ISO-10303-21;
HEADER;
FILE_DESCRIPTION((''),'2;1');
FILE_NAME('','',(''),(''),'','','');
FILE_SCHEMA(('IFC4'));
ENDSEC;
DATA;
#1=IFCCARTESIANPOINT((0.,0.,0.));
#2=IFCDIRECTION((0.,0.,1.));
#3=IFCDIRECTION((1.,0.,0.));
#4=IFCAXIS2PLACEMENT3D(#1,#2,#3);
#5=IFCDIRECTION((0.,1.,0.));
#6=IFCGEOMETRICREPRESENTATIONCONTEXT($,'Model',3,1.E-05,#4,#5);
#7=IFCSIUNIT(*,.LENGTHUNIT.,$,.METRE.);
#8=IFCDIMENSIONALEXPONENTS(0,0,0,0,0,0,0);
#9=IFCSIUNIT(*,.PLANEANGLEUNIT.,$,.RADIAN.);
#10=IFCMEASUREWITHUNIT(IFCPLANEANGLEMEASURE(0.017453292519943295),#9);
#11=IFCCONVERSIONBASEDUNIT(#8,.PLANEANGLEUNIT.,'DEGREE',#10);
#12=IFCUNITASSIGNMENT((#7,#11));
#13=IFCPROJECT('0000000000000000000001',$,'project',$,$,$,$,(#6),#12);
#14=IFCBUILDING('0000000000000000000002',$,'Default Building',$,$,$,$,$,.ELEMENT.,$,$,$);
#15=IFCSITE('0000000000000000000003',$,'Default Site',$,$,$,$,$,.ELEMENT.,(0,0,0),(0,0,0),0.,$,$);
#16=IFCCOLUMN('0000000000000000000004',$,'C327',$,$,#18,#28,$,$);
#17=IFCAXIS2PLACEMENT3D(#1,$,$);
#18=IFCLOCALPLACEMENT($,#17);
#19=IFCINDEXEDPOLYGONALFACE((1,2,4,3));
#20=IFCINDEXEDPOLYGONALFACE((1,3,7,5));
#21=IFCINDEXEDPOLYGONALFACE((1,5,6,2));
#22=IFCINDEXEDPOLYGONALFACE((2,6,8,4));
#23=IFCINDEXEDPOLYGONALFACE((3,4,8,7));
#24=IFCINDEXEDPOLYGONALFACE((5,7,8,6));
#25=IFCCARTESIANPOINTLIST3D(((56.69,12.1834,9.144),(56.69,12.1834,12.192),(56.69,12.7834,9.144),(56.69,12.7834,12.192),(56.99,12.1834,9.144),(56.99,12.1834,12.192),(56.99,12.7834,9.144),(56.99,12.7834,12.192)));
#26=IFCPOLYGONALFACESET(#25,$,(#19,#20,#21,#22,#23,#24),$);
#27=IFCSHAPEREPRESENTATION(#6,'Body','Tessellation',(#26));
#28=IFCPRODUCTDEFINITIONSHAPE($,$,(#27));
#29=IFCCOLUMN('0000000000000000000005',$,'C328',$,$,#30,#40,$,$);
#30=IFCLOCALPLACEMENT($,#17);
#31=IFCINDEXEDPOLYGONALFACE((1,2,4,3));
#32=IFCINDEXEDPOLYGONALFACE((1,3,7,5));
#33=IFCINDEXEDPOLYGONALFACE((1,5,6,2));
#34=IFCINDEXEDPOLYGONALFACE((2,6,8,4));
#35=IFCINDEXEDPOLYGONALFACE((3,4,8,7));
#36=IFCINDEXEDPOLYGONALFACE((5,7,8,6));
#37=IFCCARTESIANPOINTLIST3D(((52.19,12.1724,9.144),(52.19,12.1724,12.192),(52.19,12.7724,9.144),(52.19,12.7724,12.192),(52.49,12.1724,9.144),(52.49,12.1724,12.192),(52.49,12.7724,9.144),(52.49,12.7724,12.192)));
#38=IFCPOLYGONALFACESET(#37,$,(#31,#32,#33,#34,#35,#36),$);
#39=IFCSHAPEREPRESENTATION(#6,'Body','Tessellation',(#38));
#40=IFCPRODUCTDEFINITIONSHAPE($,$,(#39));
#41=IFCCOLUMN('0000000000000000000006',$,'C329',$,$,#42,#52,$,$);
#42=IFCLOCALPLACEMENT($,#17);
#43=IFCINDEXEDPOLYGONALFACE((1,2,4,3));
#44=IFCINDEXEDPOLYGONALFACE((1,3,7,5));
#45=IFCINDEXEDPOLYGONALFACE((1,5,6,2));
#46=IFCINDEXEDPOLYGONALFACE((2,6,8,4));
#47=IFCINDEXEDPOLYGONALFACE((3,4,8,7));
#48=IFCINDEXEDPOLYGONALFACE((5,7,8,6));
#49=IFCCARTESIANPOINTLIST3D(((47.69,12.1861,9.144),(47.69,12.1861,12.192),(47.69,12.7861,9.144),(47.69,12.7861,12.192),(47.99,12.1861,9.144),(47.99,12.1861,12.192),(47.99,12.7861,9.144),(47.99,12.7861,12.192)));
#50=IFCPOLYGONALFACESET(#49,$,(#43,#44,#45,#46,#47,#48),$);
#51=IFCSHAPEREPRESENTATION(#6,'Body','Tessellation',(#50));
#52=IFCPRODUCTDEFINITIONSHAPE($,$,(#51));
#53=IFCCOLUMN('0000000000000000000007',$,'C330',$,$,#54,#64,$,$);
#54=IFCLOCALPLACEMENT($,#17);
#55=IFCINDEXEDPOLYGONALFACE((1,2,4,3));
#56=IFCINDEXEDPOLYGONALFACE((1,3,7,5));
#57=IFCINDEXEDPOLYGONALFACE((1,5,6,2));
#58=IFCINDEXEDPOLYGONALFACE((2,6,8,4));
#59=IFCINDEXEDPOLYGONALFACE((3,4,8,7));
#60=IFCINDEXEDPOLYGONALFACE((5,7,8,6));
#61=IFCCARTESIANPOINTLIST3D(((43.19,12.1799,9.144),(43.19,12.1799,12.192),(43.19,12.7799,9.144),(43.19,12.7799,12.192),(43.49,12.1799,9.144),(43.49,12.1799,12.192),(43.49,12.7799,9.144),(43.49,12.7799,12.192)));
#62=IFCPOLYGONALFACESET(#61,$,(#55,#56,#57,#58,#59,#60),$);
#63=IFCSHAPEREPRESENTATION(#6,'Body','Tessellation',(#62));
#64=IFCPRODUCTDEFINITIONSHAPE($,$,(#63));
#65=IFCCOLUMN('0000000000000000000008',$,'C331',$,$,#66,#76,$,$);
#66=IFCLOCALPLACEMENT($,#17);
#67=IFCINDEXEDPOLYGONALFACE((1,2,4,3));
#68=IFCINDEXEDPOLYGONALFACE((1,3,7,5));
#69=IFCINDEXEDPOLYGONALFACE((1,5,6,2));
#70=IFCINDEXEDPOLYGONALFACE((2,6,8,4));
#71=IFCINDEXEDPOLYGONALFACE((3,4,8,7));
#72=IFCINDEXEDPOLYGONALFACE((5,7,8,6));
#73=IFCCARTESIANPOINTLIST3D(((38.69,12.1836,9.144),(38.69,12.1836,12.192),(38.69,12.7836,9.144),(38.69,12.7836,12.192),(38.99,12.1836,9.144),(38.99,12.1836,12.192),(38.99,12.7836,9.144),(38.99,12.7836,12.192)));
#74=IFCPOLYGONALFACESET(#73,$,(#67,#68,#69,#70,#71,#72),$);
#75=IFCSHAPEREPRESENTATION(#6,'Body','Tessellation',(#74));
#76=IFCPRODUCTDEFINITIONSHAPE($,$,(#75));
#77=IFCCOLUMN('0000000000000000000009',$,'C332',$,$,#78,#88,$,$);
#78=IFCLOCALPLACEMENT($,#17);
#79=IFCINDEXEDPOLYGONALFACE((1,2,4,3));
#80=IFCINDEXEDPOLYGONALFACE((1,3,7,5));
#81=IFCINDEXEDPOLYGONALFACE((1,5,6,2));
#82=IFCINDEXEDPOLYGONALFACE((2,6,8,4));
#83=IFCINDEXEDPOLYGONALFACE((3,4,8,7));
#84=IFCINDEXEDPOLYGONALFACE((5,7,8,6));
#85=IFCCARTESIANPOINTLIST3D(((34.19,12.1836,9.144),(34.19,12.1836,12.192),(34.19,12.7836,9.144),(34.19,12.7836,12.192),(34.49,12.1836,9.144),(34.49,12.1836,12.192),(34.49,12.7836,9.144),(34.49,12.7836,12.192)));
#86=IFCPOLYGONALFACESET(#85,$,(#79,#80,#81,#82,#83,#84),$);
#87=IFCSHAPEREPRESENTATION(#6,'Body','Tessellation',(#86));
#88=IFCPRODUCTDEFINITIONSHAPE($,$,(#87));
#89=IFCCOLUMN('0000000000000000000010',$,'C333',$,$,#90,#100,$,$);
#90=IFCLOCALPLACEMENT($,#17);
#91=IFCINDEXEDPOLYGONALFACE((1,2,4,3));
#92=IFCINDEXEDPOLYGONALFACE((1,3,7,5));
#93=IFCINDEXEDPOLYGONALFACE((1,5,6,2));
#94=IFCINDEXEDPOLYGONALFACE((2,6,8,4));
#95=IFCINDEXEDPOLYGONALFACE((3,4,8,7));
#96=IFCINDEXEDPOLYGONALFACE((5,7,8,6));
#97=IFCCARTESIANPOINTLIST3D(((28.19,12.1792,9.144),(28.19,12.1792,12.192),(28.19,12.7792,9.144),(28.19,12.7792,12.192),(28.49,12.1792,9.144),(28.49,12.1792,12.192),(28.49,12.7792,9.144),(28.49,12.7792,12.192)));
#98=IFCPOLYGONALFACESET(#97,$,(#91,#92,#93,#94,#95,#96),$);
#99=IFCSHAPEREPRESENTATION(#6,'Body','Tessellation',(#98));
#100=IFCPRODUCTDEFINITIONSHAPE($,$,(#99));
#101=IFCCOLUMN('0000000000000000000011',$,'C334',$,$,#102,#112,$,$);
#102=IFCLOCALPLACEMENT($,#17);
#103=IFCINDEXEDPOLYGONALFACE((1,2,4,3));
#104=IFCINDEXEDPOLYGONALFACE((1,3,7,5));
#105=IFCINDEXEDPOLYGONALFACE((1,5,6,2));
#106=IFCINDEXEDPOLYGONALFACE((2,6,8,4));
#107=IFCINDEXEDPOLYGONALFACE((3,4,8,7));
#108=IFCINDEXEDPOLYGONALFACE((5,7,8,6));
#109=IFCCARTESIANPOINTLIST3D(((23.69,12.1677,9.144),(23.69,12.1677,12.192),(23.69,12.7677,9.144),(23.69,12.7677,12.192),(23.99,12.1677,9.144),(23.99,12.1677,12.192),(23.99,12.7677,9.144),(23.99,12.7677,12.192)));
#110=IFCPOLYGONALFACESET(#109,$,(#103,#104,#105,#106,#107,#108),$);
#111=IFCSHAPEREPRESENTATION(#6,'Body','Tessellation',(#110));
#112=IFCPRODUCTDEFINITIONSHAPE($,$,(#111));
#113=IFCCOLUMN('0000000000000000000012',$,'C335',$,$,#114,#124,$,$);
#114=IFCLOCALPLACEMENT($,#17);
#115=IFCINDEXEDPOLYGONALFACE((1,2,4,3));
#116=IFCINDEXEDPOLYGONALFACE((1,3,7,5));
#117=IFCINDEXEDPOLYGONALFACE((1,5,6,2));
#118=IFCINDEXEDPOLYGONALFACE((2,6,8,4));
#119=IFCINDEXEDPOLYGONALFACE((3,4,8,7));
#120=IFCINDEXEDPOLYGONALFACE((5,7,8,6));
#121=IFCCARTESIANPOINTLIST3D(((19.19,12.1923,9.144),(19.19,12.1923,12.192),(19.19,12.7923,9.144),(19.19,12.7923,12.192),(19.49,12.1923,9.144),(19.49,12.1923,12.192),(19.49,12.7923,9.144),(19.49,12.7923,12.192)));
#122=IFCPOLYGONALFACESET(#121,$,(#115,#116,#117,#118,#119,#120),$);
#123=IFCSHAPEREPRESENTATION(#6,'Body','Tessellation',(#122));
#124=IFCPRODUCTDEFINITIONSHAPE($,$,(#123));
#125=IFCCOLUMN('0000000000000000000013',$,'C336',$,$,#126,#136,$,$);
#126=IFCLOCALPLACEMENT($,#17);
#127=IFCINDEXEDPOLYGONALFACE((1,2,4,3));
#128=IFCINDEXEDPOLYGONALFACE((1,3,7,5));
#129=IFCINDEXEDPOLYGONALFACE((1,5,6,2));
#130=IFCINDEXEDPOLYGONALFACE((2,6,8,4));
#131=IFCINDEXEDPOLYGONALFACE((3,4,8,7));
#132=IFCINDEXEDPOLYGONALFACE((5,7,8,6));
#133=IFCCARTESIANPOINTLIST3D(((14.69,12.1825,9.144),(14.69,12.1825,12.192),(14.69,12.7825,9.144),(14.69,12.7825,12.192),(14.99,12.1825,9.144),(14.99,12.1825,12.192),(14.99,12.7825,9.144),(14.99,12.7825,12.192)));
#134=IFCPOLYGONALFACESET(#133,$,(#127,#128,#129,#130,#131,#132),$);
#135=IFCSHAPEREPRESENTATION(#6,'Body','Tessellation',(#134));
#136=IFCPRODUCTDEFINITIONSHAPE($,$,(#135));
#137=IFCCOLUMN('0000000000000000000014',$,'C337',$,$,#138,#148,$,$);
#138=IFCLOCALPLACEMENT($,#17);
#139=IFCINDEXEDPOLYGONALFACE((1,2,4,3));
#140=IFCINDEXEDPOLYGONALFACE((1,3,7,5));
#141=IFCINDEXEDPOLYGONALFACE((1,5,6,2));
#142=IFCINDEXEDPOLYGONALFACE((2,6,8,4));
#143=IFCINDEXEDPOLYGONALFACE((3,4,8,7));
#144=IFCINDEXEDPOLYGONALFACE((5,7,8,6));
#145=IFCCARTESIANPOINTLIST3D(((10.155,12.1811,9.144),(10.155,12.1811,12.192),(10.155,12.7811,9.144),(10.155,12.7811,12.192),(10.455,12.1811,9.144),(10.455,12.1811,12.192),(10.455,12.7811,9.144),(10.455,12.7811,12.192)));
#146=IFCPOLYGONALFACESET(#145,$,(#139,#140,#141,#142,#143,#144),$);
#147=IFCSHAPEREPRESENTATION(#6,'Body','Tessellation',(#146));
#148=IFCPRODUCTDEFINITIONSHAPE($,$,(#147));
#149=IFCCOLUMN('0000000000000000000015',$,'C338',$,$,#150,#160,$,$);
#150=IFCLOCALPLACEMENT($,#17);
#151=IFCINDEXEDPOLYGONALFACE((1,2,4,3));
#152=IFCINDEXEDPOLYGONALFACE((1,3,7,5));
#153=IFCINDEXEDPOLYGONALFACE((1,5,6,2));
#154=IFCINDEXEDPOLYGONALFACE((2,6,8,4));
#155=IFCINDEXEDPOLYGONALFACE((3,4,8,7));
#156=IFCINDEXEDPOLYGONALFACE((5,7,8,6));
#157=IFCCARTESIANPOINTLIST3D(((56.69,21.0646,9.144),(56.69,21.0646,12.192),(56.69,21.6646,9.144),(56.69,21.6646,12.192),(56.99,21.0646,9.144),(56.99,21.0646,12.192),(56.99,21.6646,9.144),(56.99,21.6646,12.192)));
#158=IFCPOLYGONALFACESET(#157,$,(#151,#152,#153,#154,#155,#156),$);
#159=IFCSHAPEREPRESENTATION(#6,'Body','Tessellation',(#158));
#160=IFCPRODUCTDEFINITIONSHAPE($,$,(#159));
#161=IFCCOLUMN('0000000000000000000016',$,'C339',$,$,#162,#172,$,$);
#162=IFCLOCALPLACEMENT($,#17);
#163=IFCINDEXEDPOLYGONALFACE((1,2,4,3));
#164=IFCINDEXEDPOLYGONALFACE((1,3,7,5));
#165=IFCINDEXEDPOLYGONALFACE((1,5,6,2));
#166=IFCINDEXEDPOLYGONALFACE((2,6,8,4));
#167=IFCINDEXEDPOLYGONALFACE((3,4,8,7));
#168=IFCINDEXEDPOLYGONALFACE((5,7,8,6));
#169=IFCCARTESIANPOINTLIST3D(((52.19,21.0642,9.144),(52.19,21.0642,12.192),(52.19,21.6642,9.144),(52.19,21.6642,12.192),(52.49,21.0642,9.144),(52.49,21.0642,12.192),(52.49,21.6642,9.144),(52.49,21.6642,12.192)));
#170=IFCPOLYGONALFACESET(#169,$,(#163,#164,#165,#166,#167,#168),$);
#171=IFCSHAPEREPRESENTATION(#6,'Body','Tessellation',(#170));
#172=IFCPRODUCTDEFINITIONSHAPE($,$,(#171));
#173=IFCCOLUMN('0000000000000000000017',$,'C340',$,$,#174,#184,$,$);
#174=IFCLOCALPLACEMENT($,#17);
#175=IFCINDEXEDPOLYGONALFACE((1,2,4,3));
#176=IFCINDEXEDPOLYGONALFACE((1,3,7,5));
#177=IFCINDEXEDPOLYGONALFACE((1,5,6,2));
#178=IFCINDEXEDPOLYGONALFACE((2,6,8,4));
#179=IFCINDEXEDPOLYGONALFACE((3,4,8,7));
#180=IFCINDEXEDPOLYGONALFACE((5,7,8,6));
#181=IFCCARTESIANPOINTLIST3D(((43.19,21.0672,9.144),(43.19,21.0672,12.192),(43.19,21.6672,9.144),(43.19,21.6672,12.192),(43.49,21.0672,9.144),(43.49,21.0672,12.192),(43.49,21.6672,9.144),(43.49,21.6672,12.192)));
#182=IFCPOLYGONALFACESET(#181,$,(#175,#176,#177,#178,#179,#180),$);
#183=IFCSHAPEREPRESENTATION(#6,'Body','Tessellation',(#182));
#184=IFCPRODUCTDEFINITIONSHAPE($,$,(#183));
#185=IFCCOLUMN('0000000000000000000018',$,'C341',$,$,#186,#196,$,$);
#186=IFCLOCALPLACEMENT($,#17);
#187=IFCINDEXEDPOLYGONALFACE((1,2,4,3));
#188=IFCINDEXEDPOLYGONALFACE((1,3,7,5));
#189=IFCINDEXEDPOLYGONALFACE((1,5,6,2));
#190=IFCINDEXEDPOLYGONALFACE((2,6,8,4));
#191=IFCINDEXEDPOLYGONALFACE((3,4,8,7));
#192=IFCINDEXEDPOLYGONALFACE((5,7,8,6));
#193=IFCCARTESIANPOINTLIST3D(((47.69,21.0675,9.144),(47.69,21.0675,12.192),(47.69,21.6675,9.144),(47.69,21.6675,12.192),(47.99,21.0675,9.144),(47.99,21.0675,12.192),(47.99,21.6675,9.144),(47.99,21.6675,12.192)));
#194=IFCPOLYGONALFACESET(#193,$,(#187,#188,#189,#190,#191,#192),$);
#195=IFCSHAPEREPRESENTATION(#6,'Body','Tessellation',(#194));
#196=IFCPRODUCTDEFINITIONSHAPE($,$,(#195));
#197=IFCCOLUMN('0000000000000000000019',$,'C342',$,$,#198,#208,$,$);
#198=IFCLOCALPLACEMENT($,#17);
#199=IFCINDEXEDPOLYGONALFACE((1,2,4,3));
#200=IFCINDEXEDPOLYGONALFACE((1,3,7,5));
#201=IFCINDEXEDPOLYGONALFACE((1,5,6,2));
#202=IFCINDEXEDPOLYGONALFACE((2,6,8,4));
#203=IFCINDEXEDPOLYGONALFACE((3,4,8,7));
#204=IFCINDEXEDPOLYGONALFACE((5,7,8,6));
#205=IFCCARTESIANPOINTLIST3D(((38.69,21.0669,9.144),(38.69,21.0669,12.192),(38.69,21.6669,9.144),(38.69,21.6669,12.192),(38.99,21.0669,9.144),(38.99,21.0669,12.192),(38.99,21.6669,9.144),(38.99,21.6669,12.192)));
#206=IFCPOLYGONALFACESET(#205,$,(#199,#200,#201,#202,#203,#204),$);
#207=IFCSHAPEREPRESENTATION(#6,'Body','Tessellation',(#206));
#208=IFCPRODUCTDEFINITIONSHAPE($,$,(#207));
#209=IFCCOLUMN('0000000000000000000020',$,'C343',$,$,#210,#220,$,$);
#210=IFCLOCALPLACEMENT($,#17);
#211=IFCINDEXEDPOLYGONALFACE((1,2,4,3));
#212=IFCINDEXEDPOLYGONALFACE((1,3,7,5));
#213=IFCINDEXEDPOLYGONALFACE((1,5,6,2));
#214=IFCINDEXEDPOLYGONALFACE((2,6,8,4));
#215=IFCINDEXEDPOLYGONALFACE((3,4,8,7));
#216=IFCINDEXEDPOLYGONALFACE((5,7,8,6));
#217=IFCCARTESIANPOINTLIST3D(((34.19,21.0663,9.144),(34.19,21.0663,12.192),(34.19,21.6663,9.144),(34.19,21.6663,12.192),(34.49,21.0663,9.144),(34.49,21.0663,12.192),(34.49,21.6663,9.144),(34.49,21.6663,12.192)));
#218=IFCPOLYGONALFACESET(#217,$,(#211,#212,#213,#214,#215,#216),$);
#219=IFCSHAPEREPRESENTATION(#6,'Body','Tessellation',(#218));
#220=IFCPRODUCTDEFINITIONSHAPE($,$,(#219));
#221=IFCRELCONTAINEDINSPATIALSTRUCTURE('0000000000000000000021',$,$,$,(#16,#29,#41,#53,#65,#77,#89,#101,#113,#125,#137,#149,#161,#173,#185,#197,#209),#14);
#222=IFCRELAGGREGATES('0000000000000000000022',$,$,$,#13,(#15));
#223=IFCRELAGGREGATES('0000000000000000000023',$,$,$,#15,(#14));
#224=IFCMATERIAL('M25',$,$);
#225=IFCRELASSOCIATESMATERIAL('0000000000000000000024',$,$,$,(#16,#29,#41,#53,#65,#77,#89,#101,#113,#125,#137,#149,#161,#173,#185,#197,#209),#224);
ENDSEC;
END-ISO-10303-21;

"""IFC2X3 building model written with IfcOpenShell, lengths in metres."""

from ifc_helpers import new_model, entity, si_unit, converted_unit, direction, frame, frame_2d, origin_with_axes, place, context, project, spatial, rectangle, extrude, material, element, save


model = new_model("IFC2X3")

# Units and contexts
model_context = context("Model", 3, precision=1e-05, world=origin_with_axes(), true_north=direction((0.0, 1.0, 0.0)))
ifc_project = project(units=[si_unit("LENGTHUNIT", "METRE"), converted_unit("PLANEANGLEUNIT", "DEGREE", entity("IfcPlaneAngleMeasure", 0.017453292519943295), si_unit("PLANEANGLEUNIT", "RADIAN"), dimensions=[0, 0, 0, 0, 0, 0, 0])], contexts=[model_context])

# Site, building
site = spatial("IfcSite", under=ifc_project, Name="Default Site", CompositionType="ELEMENT", RefLatitude=(0, 0, 0), RefLongitude=(0, 0, 0), RefElevation=0.0)
building = spatial("IfcBuilding", under=site, Name="Default Building", CompositionType="ELEMENT")

# Columns
ifc_material = material(Name="M25")
placement = place(None, origin_with_axes())
element("IfcColumn", 1, at=placement, inside=building, material=ifc_material, Name="C327", context=model_context, shape_type="SweptSolid", body=[
    extrude(rectangle(XDim=0.3, YDim=0.6, at=frame_2d((0.0, 0.0), x_axis=(1.0, 0.0, 0.0))), frame((56.84, 12.4834, 9.144), z_axis=(0.0, 0.0, 1.0), x_axis=(1.0, 0.0, 0.0)), (0.0, 0.0, 1.0), 3.048),
])
element("IfcColumn", 2, at=placement, inside=building, material=ifc_material, Name="C328", context=model_context, shape_type="SweptSolid", body=[
    extrude(rectangle(XDim=0.3, YDim=0.6, at=frame_2d((0.0, 0.0), x_axis=(1.0, 0.0, 0.0))), frame((52.34, 12.4724, 9.144), z_axis=(0.0, 0.0, 1.0), x_axis=(1.0, 0.0, 0.0)), (0.0, 0.0, 1.0), 3.048),
])
element("IfcColumn", 3, at=placement, inside=building, material=ifc_material, Name="C329", context=model_context, shape_type="SweptSolid", body=[
    extrude(rectangle(XDim=0.3, YDim=0.6, at=frame_2d((0.0, 0.0), x_axis=(1.0, 0.0, 0.0))), frame((47.84, 12.4861, 9.144), z_axis=(0.0, 0.0, 1.0), x_axis=(1.0, 0.0, 0.0)), (0.0, 0.0, 1.0), 3.048),
])
element("IfcColumn", 4, at=placement, inside=building, material=ifc_material, Name="C330", context=model_context, shape_type="SweptSolid", body=[
    extrude(rectangle(XDim=0.3, YDim=0.6, at=frame_2d((0.0, 0.0), x_axis=(1.0, 0.0, 0.0))), frame((43.34, 12.4799, 9.144), z_axis=(0.0, 0.0, 1.0), x_axis=(1.0, 0.0, 0.0)), (0.0, 0.0, 1.0), 3.048),
])
element("IfcColumn", 5, at=placement, inside=building, material=ifc_material, Name="C331", context=model_context, shape_type="SweptSolid", body=[
    extrude(rectangle(XDim=0.3, YDim=0.6, at=frame_2d((0.0, 0.0), x_axis=(1.0, 0.0, 0.0))), frame((38.84, 12.4836, 9.144), z_axis=(0.0, 0.0, 1.0), x_axis=(1.0, 0.0, 0.0)), (0.0, 0.0, 1.0), 3.048),
])
element("IfcColumn", 6, at=placement, inside=building, material=ifc_material, Name="C332", context=model_context, shape_type="SweptSolid", body=[
    extrude(rectangle(XDim=0.3, YDim=0.6, at=frame_2d((0.0, 0.0), x_axis=(1.0, 0.0, 0.0))), frame((34.34, 12.4836, 9.144), z_axis=(0.0, 0.0, 1.0), x_axis=(1.0, 0.0, 0.0)), (0.0, 0.0, 1.0), 3.048),
])
element("IfcColumn", 7, at=placement, inside=building, material=ifc_material, Name="C333", context=model_context, shape_type="SweptSolid", body=[
    extrude(rectangle(XDim=0.3, YDim=0.6, at=frame_2d((0.0, 0.0), x_axis=(1.0, 0.0, 0.0))), frame((28.34, 12.4792, 9.144), z_axis=(0.0, 0.0, 1.0), x_axis=(1.0, 0.0, 0.0)), (0.0, 0.0, 1.0), 3.048),
])
element("IfcColumn", 8, at=placement, inside=building, material=ifc_material, Name="C334", context=model_context, shape_type="SweptSolid", body=[
    extrude(rectangle(XDim=0.3, YDim=0.6, at=frame_2d((0.0, 0.0), x_axis=(1.0, 0.0, 0.0))), frame((23.84, 12.4677, 9.144), z_axis=(0.0, 0.0, 1.0), x_axis=(1.0, 0.0, 0.0)), (0.0, 0.0, 1.0), 3.048),
])
element("IfcColumn", 9, at=placement, inside=building, material=ifc_material, Name="C335", context=model_context, shape_type="SweptSolid", body=[
    extrude(rectangle(XDim=0.3, YDim=0.6, at=frame_2d((0.0, 0.0), x_axis=(1.0, 0.0, 0.0))), frame((19.34, 12.4923, 9.144), z_axis=(0.0, 0.0, 1.0), x_axis=(1.0, 0.0, 0.0)), (0.0, 0.0, 1.0), 3.048),
])
element("IfcColumn", 10, at=placement, inside=building, material=ifc_material, Name="C336", context=model_context, shape_type="SweptSolid", body=[
    extrude(rectangle(XDim=0.3, YDim=0.6, at=frame_2d((0.0, 0.0), x_axis=(1.0, 0.0, 0.0))), frame((14.84, 12.4825, 9.144), z_axis=(0.0, 0.0, 1.0), x_axis=(1.0, 0.0, 0.0)), (0.0, 0.0, 1.0), 3.048),
])
element("IfcColumn", 11, at=placement, inside=building, material=ifc_material, Name="C337", context=model_context, shape_type="SweptSolid", body=[
    extrude(rectangle(XDim=0.3, YDim=0.6, at=frame_2d((0.0, 0.0), x_axis=(1.0, 0.0, 0.0))), frame((10.305, 12.4811, 9.144), z_axis=(0.0, 0.0, 1.0), x_axis=(1.0, 0.0, 0.0)), (0.0, 0.0, 1.0), 3.048),
])
element("IfcColumn", 12, at=placement, inside=building, material=ifc_material, Name="C338", context=model_context, shape_type="SweptSolid", body=[
    extrude(rectangle(XDim=0.3, YDim=0.6, at=frame_2d((0.0, 0.0), x_axis=(1.0, 0.0, 0.0))), frame((56.84, 21.3646, 9.144), z_axis=(0.0, 0.0, 1.0), x_axis=(1.0, 0.0, 0.0)), (0.0, 0.0, 1.0), 3.048),
])
element("IfcColumn", 13, at=placement, inside=building, material=ifc_material, Name="C339", context=model_context, shape_type="SweptSolid", body=[
    extrude(rectangle(XDim=0.3, YDim=0.6, at=frame_2d((0.0, 0.0), x_axis=(1.0, 0.0, 0.0))), frame((52.34, 21.3642, 9.144), z_axis=(0.0, 0.0, 1.0), x_axis=(1.0, 0.0, 0.0)), (0.0, 0.0, 1.0), 3.048),
])
element("IfcColumn", 14, at=placement, inside=building, material=ifc_material, Name="C340", context=model_context, shape_type="SweptSolid", body=[
    extrude(rectangle(XDim=0.3, YDim=0.6, at=frame_2d((0.0, 0.0), x_axis=(1.0, 0.0, 0.0))), frame((43.34, 21.3672, 9.144), z_axis=(0.0, 0.0, 1.0), x_axis=(1.0, 0.0, 0.0)), (0.0, 0.0, 1.0), 3.048),
])
element("IfcColumn", 15, at=placement, inside=building, material=ifc_material, Name="C341", context=model_context, shape_type="SweptSolid", body=[
    extrude(rectangle(XDim=0.3, YDim=0.6, at=frame_2d((0.0, 0.0), x_axis=(1.0, 0.0, 0.0))), frame((47.84, 21.3675, 9.144), z_axis=(0.0, 0.0, 1.0), x_axis=(1.0, 0.0, 0.0)), (0.0, 0.0, 1.0), 3.048),
])
element("IfcColumn", 16, at=placement, inside=building, material=ifc_material, Name="C342", context=model_context, shape_type="SweptSolid", body=[
    extrude(rectangle(XDim=0.3, YDim=0.6, at=frame_2d((0.0, 0.0), x_axis=(1.0, 0.0, 0.0))), frame((38.84, 21.3669, 9.144), z_axis=(0.0, 0.0, 1.0), x_axis=(1.0, 0.0, 0.0)), (0.0, 0.0, 1.0), 3.048),
])
element("IfcColumn", 17, at=placement, inside=building, material=ifc_material, Name="C343", context=model_context, shape_type="SweptSolid", body=[
    extrude(rectangle(XDim=0.3, YDim=0.6, at=frame_2d((0.0, 0.0), x_axis=(1.0, 0.0, 0.0))), frame((34.34, 21.3663, 9.144), z_axis=(0.0, 0.0, 1.0), x_axis=(1.0, 0.0, 0.0)), (0.0, 0.0, 1.0), 3.048),
])

save(model, "model.ifc")
